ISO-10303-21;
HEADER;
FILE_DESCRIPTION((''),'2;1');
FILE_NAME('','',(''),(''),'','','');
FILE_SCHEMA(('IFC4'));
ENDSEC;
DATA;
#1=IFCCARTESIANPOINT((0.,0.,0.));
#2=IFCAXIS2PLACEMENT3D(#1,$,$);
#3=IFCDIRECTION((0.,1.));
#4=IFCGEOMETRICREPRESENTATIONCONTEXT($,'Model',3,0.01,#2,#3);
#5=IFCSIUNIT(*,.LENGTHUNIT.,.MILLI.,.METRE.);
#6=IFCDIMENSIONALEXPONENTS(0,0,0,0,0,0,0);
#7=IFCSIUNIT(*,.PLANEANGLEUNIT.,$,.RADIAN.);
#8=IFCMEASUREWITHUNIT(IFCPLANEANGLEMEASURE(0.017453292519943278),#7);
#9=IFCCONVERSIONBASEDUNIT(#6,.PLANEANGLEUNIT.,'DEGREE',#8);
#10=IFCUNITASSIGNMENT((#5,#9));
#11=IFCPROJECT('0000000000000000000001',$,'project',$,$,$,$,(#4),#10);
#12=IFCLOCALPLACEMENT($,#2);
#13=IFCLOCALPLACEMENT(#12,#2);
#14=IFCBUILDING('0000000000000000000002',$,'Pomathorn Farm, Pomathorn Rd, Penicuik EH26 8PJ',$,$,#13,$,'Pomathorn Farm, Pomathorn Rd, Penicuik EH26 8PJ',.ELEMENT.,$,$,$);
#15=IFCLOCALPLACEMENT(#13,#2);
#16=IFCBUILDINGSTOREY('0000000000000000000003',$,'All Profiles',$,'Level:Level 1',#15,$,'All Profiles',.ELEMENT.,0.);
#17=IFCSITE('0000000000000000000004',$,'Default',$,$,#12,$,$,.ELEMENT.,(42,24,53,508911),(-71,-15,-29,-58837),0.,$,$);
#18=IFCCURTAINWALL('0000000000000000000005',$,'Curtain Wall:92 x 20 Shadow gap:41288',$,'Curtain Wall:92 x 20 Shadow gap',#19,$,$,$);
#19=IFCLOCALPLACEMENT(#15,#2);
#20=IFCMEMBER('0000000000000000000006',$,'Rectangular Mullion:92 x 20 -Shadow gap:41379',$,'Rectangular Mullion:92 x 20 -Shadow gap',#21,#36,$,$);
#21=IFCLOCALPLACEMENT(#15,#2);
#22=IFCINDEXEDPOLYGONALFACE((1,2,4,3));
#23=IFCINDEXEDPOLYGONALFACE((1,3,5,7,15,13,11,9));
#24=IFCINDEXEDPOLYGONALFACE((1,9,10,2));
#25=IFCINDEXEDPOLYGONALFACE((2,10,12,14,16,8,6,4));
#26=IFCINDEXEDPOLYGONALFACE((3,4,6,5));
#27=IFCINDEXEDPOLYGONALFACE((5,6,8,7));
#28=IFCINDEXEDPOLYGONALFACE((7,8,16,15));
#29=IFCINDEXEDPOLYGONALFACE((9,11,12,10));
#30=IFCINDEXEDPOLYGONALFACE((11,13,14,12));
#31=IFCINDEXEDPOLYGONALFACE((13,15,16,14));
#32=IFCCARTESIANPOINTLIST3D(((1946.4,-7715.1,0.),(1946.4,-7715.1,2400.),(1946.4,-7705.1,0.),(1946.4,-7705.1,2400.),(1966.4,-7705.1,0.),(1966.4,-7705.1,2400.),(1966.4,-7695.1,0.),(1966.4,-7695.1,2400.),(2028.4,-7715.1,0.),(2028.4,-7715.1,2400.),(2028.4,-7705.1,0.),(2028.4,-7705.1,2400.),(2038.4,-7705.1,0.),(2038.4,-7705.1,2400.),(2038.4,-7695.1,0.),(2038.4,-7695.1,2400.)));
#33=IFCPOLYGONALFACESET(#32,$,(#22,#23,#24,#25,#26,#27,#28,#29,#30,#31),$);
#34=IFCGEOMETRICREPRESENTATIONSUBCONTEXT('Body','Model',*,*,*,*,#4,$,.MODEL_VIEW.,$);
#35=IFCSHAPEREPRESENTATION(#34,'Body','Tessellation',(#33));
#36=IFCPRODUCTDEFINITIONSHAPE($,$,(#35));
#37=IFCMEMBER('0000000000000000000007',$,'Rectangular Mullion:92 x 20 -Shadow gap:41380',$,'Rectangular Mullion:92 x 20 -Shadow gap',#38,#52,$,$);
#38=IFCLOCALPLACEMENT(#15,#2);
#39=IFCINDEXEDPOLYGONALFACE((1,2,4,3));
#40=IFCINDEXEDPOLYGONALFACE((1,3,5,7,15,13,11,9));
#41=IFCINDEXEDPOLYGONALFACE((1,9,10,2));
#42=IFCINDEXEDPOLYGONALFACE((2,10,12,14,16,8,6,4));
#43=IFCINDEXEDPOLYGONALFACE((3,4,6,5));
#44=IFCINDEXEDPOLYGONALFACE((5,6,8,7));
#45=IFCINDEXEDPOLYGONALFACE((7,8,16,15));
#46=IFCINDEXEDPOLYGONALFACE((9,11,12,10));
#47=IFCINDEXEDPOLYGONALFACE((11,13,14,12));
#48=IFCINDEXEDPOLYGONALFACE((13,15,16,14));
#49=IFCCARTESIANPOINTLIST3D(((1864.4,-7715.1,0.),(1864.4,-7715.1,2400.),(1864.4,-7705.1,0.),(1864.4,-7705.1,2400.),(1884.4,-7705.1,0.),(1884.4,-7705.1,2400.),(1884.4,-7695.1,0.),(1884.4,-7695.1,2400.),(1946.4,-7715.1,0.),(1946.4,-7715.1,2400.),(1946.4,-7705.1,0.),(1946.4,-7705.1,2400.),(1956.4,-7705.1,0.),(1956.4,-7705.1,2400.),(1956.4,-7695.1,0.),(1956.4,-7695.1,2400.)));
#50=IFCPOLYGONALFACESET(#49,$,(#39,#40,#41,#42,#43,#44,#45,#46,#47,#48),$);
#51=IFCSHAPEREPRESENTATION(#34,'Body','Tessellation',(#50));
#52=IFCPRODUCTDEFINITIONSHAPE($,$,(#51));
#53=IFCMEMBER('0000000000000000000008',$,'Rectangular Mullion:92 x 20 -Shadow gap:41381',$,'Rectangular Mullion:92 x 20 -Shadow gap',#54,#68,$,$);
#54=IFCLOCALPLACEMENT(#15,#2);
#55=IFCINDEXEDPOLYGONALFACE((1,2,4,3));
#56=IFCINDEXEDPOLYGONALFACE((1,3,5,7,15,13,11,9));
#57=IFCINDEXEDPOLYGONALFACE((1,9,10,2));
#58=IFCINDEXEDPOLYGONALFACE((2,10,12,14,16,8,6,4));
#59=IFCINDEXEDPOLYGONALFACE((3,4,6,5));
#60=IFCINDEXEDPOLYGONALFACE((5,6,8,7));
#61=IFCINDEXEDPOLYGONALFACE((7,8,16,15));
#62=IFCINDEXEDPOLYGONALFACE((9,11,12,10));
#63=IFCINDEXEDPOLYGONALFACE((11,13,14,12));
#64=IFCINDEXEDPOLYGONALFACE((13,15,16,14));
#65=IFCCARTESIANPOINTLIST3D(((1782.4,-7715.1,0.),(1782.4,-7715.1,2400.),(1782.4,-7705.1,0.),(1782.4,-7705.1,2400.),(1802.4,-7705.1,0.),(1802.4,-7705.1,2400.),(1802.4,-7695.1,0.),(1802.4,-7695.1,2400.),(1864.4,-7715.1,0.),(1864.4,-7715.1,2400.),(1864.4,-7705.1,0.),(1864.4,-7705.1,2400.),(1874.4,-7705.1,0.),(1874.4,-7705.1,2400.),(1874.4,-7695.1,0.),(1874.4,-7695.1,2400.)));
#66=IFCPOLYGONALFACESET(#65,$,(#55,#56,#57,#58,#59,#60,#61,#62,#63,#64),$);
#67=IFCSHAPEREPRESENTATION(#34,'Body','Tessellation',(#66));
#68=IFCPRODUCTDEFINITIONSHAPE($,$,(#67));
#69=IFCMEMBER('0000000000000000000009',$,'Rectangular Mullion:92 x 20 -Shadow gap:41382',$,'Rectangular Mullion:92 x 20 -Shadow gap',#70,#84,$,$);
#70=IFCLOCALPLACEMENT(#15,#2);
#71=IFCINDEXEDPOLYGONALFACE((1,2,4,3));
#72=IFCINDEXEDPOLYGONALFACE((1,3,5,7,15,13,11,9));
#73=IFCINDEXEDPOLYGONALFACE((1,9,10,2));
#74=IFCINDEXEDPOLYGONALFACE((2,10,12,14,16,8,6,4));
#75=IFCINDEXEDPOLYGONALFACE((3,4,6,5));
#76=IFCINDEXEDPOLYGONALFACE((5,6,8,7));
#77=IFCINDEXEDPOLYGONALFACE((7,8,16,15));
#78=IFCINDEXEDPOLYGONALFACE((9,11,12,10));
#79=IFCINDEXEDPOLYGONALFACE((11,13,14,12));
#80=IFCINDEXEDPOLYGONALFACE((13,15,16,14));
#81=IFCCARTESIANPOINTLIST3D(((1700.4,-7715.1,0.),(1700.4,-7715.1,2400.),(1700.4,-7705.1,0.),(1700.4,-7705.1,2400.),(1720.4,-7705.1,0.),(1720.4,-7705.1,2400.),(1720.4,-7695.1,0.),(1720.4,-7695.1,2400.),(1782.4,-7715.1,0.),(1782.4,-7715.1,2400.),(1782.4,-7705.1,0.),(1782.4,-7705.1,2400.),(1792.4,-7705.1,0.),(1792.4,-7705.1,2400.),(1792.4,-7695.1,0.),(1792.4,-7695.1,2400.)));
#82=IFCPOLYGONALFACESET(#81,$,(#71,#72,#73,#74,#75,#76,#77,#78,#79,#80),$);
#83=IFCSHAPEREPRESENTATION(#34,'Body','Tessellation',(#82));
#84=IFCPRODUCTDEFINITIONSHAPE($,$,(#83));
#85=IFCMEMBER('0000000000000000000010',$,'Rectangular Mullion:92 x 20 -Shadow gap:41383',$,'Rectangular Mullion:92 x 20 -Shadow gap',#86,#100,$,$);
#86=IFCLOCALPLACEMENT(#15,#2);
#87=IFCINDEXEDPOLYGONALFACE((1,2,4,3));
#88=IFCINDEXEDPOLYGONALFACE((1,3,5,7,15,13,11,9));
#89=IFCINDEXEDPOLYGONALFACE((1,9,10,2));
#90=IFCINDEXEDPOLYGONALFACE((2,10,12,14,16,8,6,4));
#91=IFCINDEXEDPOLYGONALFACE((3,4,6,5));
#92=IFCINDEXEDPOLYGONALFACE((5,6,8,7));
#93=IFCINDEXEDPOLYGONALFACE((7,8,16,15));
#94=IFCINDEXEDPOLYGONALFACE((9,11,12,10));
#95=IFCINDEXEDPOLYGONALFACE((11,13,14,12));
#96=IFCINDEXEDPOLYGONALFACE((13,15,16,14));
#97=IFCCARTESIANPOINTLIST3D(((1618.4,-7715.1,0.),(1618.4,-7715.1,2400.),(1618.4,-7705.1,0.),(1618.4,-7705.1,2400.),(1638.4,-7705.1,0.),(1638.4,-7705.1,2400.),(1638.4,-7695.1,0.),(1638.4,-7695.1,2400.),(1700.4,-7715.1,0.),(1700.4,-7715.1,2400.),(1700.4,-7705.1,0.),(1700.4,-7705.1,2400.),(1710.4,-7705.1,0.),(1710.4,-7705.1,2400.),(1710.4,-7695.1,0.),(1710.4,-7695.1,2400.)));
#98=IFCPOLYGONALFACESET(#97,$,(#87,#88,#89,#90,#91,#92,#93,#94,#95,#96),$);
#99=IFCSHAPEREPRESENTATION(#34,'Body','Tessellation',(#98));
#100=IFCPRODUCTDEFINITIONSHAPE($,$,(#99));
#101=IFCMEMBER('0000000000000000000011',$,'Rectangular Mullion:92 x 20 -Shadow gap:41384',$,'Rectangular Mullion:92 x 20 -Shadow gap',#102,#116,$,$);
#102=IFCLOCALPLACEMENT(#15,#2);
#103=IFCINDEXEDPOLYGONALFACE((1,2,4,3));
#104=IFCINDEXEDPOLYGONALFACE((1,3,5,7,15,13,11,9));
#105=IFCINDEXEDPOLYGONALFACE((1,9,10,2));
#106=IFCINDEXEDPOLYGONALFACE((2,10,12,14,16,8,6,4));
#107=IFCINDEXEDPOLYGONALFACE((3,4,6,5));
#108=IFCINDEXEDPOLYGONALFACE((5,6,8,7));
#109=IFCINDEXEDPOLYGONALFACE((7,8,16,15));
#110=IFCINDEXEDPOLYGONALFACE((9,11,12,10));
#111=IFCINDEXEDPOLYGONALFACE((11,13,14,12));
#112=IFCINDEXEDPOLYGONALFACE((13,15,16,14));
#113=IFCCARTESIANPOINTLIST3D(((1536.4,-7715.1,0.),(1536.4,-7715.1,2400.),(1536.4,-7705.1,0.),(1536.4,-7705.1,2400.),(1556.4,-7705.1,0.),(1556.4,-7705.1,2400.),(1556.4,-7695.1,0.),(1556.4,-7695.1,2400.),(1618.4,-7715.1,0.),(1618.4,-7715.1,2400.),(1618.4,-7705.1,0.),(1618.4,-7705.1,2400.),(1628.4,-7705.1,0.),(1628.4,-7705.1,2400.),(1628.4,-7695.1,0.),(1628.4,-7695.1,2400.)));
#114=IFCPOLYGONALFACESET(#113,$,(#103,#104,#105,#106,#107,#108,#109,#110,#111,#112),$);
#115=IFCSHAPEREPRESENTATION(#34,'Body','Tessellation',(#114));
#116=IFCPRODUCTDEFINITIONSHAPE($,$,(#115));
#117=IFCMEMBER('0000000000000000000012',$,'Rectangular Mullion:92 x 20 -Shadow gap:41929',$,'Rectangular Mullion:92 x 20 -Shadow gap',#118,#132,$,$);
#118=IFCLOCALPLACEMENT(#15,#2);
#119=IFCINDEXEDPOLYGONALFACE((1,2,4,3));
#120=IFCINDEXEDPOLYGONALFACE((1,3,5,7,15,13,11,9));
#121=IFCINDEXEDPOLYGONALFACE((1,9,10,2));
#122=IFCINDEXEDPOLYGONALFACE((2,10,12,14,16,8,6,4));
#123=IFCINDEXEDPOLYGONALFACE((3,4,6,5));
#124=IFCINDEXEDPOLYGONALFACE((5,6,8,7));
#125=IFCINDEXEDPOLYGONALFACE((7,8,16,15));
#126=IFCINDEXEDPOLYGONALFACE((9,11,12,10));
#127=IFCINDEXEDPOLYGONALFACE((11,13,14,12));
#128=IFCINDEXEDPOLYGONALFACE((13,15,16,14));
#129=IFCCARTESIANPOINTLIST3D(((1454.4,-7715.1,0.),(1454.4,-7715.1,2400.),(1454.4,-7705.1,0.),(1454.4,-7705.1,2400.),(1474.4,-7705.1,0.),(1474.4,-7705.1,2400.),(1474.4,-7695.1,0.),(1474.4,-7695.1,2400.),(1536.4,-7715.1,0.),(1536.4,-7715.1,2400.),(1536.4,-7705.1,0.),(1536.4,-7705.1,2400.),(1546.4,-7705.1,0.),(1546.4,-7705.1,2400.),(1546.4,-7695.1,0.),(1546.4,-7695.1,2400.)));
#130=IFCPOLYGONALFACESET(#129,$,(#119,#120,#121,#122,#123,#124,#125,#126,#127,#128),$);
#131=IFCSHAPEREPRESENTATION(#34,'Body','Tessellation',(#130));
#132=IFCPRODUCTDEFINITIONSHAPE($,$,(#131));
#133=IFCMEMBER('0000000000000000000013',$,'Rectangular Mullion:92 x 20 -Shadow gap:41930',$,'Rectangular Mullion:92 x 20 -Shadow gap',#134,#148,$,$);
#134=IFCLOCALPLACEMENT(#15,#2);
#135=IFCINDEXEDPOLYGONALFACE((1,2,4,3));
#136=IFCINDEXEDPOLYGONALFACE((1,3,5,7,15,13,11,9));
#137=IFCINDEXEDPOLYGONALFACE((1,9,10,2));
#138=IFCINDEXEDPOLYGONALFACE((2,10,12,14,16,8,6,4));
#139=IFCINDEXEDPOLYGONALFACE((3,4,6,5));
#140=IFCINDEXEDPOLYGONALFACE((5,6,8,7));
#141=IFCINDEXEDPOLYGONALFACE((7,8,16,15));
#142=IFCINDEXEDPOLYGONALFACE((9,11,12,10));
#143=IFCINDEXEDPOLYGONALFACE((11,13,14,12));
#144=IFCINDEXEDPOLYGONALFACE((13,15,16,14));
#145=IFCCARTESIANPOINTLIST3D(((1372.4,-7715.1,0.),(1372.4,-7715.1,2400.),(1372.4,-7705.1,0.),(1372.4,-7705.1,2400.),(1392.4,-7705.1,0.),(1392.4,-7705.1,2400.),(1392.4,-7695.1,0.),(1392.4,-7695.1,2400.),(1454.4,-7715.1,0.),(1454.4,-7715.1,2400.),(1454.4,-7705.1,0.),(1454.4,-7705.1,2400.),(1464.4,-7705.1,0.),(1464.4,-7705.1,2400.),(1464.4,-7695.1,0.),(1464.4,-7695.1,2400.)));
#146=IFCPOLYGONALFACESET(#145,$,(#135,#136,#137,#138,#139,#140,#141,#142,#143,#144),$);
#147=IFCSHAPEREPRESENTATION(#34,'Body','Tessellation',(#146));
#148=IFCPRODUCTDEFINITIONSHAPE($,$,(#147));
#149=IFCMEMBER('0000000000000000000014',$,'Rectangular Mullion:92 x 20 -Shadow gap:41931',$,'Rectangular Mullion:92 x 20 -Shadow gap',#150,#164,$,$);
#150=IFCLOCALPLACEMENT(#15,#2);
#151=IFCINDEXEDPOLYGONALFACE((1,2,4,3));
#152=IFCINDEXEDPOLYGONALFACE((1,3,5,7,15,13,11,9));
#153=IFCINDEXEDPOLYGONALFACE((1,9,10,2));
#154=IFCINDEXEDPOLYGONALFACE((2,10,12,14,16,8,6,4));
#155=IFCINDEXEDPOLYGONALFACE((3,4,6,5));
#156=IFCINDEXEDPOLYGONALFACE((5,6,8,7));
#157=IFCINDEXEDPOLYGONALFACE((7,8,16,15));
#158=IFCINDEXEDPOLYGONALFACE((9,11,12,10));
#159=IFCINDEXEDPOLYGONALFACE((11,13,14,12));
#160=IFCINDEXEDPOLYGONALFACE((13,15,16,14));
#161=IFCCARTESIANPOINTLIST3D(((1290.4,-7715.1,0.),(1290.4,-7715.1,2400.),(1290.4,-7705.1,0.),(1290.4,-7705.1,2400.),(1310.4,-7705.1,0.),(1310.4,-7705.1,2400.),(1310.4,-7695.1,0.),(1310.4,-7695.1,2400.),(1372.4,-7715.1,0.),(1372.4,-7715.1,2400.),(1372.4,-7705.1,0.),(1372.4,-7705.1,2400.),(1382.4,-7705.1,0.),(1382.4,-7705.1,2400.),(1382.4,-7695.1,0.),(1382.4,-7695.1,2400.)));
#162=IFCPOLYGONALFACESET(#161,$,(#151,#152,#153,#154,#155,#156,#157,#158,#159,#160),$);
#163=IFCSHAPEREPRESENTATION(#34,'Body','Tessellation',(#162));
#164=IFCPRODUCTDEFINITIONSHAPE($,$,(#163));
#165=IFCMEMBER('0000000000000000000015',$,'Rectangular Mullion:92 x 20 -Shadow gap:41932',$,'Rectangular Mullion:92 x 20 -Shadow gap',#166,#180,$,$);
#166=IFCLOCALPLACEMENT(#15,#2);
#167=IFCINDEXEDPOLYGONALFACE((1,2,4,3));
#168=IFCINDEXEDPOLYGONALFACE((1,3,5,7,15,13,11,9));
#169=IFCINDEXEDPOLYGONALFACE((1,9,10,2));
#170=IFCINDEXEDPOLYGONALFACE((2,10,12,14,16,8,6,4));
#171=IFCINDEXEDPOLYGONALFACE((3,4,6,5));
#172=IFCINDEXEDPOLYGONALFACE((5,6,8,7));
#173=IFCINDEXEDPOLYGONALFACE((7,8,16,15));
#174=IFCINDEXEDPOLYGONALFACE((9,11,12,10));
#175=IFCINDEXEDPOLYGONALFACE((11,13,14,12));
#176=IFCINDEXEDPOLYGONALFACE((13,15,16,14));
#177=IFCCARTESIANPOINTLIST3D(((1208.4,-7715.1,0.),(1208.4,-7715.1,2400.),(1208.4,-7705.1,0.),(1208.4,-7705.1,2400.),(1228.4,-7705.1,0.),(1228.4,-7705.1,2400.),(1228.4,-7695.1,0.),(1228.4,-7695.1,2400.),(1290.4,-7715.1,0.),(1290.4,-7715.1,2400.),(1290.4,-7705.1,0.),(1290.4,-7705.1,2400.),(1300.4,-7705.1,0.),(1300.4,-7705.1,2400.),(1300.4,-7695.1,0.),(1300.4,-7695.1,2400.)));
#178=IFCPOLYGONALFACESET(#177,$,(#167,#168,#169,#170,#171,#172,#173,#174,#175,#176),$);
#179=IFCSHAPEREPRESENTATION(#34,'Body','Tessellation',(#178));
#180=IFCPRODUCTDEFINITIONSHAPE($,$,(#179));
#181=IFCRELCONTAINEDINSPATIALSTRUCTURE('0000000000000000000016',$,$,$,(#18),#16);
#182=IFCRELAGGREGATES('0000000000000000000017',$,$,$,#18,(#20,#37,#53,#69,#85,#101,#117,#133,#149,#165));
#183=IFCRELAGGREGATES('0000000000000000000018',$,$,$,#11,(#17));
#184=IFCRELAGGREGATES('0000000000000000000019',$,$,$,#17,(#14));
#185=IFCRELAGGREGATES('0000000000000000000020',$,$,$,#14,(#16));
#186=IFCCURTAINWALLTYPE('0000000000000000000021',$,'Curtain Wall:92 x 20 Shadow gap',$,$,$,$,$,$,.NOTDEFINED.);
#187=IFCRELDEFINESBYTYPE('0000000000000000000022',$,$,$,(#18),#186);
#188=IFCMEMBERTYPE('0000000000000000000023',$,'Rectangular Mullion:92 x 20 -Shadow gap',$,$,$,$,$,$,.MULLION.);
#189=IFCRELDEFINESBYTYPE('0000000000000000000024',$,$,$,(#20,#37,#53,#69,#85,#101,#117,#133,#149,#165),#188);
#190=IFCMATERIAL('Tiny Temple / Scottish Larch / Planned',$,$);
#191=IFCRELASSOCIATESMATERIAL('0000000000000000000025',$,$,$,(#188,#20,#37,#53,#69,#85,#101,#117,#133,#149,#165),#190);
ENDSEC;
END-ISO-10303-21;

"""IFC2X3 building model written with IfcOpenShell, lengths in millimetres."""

from ifc_helpers import new_model, entity, si_unit, converted_unit, direction, frame, origin, place, context, subcontext, project, spatial, polyline, outline, extrude, source, transform, mapped, material, type_object, type_shapes, element, aggregate, save


model = new_model("IFC2X3")

# Units and contexts
model_context = context("Model", 3, precision=0.01, world=origin(), true_north=direction((0.0, 1.0)))
body_context = subcontext(model_context, "Body", "Model", "MODEL_VIEW")
ifc_project = project(units=[si_unit("LENGTHUNIT", "METRE", prefix="MILLI"), converted_unit("PLANEANGLEUNIT", "DEGREE", entity("IfcPlaneAngleMeasure", 0.017453292519943278), si_unit("PLANEANGLEUNIT", "RADIAN"), dimensions=[0, 0, 0, 0, 0, 0, 0])], contexts=[model_context])

# Site, building, storey
site_placement = place(None, origin())
site = spatial("IfcSite", under=ifc_project, at=site_placement, Name="Default", CompositionType="ELEMENT", RefLatitude=(42, 24, 53, 508911), RefLongitude=(-71, -15, -29, -58837), RefElevation=0.0)
building_placement = place(site_placement, origin())
building = spatial("IfcBuilding", under=site, at=building_placement, Name="Pomathorn Farm, Pomathorn Rd, Penicuik EH26 8PJ", LongName="Pomathorn Farm, Pomathorn Rd, Penicuik EH26 8PJ", CompositionType="ELEMENT")
storey_placement = place(building_placement, origin())
storey = spatial("IfcBuildingStorey", under=building, at=storey_placement, Name="All Profiles", ObjectType="Level:Level 1", LongName="All Profiles", CompositionType="ELEMENT", Elevation=0.0)

# Curtain wall, members
curtain_wall_type_1 = type_object("IfcCurtainWallType", Name="Curtain Wall:92 x 20 Shadow gap", PredefinedType="NOTDEFINED")
curtain_wall_1_placement = place(storey_placement, origin())
curtain_wall_1 = element("IfcCurtainWall", 1, at=curtain_wall_1_placement, inside=storey, type_object=curtain_wall_type_1, Name="Curtain Wall:92 x 20 Shadow gap:41288", ObjectType="Curtain Wall:92 x 20 Shadow gap")
ifc_material = material(Name="Tiny Temple / Scottish Larch / Planned")
member_type_1 = type_object("IfcMemberType", Name="Rectangular Mullion:92 x 20 -Shadow gap", PredefinedType="MULLION", material=ifc_material)
shared_shape_1 = source(origin(), body_context, "Body", "SweptSolid", [
    extrude(outline(polyline([(-48.5, 0.0), (-48.5, -10.0), (33.5, -10.0), (33.5, 0.0), (43.5, 0.0), (43.5, 10.0), (-28.5, 10.0), (-28.5, 0.0), (-48.5, 0.0)])), frame((-43.5, -10.0, -2400.0), z_axis=(0.0, 0.0, -1.0), x_axis=(1.0, 0.0, 0.0)), (0.0, 0.0, -1.0), 2400.0),
])
type_shapes(member_type_1, [shared_shape_1])
member_1_placement = place(curtain_wall_1_placement, frame((2038.4, -7715.1, 0.0), z_axis=(0.0, 0.0, -1.0), x_axis=(1.0, 0.0, 0.0)))
member_1 = element("IfcMember", 2, at=member_1_placement, type_object=member_type_1, material=ifc_material, Name="Rectangular Mullion:92 x 20 -Shadow gap:41379", ObjectType="Rectangular Mullion:92 x 20 -Shadow gap", context=body_context, shape_type="MappedRepresentation", body=[
    mapped(shared_shape_1, transform((0.0, 0.0, 0.0), scale=1.0)),
])
member_2_placement = place(curtain_wall_1_placement, frame((1956.4, -7715.1, 0.0), z_axis=(0.0, 0.0, -1.0), x_axis=(1.0, 0.0, 0.0)))
member_2 = element("IfcMember", 3, at=member_2_placement, type_object=member_type_1, material=ifc_material, Name="Rectangular Mullion:92 x 20 -Shadow gap:41380", ObjectType="Rectangular Mullion:92 x 20 -Shadow gap", context=body_context, shape_type="MappedRepresentation", body=[
    mapped(shared_shape_1, transform((0.0, 0.0, 0.0), scale=1.0)),
])
member_3_placement = place(curtain_wall_1_placement, frame((1874.4, -7715.1, 0.0), z_axis=(0.0, 0.0, -1.0), x_axis=(1.0, 0.0, 0.0)))
member_3 = element("IfcMember", 4, at=member_3_placement, type_object=member_type_1, material=ifc_material, Name="Rectangular Mullion:92 x 20 -Shadow gap:41381", ObjectType="Rectangular Mullion:92 x 20 -Shadow gap", context=body_context, shape_type="MappedRepresentation", body=[
    mapped(shared_shape_1, transform((0.0, 0.0, 0.0), scale=1.0)),
])
member_4_placement = place(curtain_wall_1_placement, frame((1792.4, -7715.1, 0.0), z_axis=(0.0, 0.0, -1.0), x_axis=(1.0, 0.0, 0.0)))
member_4 = element("IfcMember", 5, at=member_4_placement, type_object=member_type_1, material=ifc_material, Name="Rectangular Mullion:92 x 20 -Shadow gap:41382", ObjectType="Rectangular Mullion:92 x 20 -Shadow gap", context=body_context, shape_type="MappedRepresentation", body=[
    mapped(shared_shape_1, transform((0.0, 0.0, 0.0), scale=1.0)),
])
member_5_placement = place(curtain_wall_1_placement, frame((1710.4, -7715.1, 0.0), z_axis=(0.0, 0.0, -1.0), x_axis=(1.0, 0.0, 0.0)))
member_5 = element("IfcMember", 6, at=member_5_placement, type_object=member_type_1, material=ifc_material, Name="Rectangular Mullion:92 x 20 -Shadow gap:41383", ObjectType="Rectangular Mullion:92 x 20 -Shadow gap", context=body_context, shape_type="MappedRepresentation", body=[
    mapped(shared_shape_1, transform((0.0, 0.0, 0.0), scale=1.0)),
])
member_6_placement = place(curtain_wall_1_placement, frame((1628.4, -7715.1, 0.0), z_axis=(0.0, 0.0, -1.0), x_axis=(1.0, 0.0, 0.0)))
member_6 = element("IfcMember", 7, at=member_6_placement, type_object=member_type_1, material=ifc_material, Name="Rectangular Mullion:92 x 20 -Shadow gap:41384", ObjectType="Rectangular Mullion:92 x 20 -Shadow gap", context=body_context, shape_type="MappedRepresentation", body=[
    mapped(shared_shape_1, transform((0.0, 0.0, 0.0), scale=1.0)),
])
member_7_placement = place(curtain_wall_1_placement, frame((1546.4, -7715.1, 0.0), z_axis=(0.0, 0.0, -1.0), x_axis=(1.0, 0.0, 0.0)))
member_7 = element("IfcMember", 8, at=member_7_placement, type_object=member_type_1, material=ifc_material, Name="Rectangular Mullion:92 x 20 -Shadow gap:41929", ObjectType="Rectangular Mullion:92 x 20 -Shadow gap", context=body_context, shape_type="MappedRepresentation", body=[
    mapped(shared_shape_1, transform((0.0, 0.0, 0.0), scale=1.0)),
])
member_8_placement = place(curtain_wall_1_placement, frame((1464.4, -7715.1, 0.0), z_axis=(0.0, 0.0, -1.0), x_axis=(1.0, 0.0, 0.0)))
member_8 = element("IfcMember", 9, at=member_8_placement, type_object=member_type_1, material=ifc_material, Name="Rectangular Mullion:92 x 20 -Shadow gap:41930", ObjectType="Rectangular Mullion:92 x 20 -Shadow gap", context=body_context, shape_type="MappedRepresentation", body=[
    mapped(shared_shape_1, transform((0.0, 0.0, 0.0), scale=1.0)),
])
member_9_placement = place(curtain_wall_1_placement, frame((1382.4, -7715.1, 0.0), z_axis=(0.0, 0.0, -1.0), x_axis=(1.0, 0.0, 0.0)))
member_9 = element("IfcMember", 10, at=member_9_placement, type_object=member_type_1, material=ifc_material, Name="Rectangular Mullion:92 x 20 -Shadow gap:41931", ObjectType="Rectangular Mullion:92 x 20 -Shadow gap", context=body_context, shape_type="MappedRepresentation", body=[
    mapped(shared_shape_1, transform((0.0, 0.0, 0.0), scale=1.0)),
])
member_10_placement = place(curtain_wall_1_placement, frame((1300.4, -7715.1, 0.0), z_axis=(0.0, 0.0, -1.0), x_axis=(1.0, 0.0, 0.0)))
member_10 = element("IfcMember", 11, at=member_10_placement, type_object=member_type_1, material=ifc_material, Name="Rectangular Mullion:92 x 20 -Shadow gap:41932", ObjectType="Rectangular Mullion:92 x 20 -Shadow gap", context=body_context, shape_type="MappedRepresentation", body=[
    mapped(shared_shape_1, transform((0.0, 0.0, 0.0), scale=1.0)),
])
aggregate(curtain_wall_1, [member_1, member_2, member_3, member_4, member_5, member_6, member_7, member_8, member_9, member_10])

save(model, "model.ifc")
